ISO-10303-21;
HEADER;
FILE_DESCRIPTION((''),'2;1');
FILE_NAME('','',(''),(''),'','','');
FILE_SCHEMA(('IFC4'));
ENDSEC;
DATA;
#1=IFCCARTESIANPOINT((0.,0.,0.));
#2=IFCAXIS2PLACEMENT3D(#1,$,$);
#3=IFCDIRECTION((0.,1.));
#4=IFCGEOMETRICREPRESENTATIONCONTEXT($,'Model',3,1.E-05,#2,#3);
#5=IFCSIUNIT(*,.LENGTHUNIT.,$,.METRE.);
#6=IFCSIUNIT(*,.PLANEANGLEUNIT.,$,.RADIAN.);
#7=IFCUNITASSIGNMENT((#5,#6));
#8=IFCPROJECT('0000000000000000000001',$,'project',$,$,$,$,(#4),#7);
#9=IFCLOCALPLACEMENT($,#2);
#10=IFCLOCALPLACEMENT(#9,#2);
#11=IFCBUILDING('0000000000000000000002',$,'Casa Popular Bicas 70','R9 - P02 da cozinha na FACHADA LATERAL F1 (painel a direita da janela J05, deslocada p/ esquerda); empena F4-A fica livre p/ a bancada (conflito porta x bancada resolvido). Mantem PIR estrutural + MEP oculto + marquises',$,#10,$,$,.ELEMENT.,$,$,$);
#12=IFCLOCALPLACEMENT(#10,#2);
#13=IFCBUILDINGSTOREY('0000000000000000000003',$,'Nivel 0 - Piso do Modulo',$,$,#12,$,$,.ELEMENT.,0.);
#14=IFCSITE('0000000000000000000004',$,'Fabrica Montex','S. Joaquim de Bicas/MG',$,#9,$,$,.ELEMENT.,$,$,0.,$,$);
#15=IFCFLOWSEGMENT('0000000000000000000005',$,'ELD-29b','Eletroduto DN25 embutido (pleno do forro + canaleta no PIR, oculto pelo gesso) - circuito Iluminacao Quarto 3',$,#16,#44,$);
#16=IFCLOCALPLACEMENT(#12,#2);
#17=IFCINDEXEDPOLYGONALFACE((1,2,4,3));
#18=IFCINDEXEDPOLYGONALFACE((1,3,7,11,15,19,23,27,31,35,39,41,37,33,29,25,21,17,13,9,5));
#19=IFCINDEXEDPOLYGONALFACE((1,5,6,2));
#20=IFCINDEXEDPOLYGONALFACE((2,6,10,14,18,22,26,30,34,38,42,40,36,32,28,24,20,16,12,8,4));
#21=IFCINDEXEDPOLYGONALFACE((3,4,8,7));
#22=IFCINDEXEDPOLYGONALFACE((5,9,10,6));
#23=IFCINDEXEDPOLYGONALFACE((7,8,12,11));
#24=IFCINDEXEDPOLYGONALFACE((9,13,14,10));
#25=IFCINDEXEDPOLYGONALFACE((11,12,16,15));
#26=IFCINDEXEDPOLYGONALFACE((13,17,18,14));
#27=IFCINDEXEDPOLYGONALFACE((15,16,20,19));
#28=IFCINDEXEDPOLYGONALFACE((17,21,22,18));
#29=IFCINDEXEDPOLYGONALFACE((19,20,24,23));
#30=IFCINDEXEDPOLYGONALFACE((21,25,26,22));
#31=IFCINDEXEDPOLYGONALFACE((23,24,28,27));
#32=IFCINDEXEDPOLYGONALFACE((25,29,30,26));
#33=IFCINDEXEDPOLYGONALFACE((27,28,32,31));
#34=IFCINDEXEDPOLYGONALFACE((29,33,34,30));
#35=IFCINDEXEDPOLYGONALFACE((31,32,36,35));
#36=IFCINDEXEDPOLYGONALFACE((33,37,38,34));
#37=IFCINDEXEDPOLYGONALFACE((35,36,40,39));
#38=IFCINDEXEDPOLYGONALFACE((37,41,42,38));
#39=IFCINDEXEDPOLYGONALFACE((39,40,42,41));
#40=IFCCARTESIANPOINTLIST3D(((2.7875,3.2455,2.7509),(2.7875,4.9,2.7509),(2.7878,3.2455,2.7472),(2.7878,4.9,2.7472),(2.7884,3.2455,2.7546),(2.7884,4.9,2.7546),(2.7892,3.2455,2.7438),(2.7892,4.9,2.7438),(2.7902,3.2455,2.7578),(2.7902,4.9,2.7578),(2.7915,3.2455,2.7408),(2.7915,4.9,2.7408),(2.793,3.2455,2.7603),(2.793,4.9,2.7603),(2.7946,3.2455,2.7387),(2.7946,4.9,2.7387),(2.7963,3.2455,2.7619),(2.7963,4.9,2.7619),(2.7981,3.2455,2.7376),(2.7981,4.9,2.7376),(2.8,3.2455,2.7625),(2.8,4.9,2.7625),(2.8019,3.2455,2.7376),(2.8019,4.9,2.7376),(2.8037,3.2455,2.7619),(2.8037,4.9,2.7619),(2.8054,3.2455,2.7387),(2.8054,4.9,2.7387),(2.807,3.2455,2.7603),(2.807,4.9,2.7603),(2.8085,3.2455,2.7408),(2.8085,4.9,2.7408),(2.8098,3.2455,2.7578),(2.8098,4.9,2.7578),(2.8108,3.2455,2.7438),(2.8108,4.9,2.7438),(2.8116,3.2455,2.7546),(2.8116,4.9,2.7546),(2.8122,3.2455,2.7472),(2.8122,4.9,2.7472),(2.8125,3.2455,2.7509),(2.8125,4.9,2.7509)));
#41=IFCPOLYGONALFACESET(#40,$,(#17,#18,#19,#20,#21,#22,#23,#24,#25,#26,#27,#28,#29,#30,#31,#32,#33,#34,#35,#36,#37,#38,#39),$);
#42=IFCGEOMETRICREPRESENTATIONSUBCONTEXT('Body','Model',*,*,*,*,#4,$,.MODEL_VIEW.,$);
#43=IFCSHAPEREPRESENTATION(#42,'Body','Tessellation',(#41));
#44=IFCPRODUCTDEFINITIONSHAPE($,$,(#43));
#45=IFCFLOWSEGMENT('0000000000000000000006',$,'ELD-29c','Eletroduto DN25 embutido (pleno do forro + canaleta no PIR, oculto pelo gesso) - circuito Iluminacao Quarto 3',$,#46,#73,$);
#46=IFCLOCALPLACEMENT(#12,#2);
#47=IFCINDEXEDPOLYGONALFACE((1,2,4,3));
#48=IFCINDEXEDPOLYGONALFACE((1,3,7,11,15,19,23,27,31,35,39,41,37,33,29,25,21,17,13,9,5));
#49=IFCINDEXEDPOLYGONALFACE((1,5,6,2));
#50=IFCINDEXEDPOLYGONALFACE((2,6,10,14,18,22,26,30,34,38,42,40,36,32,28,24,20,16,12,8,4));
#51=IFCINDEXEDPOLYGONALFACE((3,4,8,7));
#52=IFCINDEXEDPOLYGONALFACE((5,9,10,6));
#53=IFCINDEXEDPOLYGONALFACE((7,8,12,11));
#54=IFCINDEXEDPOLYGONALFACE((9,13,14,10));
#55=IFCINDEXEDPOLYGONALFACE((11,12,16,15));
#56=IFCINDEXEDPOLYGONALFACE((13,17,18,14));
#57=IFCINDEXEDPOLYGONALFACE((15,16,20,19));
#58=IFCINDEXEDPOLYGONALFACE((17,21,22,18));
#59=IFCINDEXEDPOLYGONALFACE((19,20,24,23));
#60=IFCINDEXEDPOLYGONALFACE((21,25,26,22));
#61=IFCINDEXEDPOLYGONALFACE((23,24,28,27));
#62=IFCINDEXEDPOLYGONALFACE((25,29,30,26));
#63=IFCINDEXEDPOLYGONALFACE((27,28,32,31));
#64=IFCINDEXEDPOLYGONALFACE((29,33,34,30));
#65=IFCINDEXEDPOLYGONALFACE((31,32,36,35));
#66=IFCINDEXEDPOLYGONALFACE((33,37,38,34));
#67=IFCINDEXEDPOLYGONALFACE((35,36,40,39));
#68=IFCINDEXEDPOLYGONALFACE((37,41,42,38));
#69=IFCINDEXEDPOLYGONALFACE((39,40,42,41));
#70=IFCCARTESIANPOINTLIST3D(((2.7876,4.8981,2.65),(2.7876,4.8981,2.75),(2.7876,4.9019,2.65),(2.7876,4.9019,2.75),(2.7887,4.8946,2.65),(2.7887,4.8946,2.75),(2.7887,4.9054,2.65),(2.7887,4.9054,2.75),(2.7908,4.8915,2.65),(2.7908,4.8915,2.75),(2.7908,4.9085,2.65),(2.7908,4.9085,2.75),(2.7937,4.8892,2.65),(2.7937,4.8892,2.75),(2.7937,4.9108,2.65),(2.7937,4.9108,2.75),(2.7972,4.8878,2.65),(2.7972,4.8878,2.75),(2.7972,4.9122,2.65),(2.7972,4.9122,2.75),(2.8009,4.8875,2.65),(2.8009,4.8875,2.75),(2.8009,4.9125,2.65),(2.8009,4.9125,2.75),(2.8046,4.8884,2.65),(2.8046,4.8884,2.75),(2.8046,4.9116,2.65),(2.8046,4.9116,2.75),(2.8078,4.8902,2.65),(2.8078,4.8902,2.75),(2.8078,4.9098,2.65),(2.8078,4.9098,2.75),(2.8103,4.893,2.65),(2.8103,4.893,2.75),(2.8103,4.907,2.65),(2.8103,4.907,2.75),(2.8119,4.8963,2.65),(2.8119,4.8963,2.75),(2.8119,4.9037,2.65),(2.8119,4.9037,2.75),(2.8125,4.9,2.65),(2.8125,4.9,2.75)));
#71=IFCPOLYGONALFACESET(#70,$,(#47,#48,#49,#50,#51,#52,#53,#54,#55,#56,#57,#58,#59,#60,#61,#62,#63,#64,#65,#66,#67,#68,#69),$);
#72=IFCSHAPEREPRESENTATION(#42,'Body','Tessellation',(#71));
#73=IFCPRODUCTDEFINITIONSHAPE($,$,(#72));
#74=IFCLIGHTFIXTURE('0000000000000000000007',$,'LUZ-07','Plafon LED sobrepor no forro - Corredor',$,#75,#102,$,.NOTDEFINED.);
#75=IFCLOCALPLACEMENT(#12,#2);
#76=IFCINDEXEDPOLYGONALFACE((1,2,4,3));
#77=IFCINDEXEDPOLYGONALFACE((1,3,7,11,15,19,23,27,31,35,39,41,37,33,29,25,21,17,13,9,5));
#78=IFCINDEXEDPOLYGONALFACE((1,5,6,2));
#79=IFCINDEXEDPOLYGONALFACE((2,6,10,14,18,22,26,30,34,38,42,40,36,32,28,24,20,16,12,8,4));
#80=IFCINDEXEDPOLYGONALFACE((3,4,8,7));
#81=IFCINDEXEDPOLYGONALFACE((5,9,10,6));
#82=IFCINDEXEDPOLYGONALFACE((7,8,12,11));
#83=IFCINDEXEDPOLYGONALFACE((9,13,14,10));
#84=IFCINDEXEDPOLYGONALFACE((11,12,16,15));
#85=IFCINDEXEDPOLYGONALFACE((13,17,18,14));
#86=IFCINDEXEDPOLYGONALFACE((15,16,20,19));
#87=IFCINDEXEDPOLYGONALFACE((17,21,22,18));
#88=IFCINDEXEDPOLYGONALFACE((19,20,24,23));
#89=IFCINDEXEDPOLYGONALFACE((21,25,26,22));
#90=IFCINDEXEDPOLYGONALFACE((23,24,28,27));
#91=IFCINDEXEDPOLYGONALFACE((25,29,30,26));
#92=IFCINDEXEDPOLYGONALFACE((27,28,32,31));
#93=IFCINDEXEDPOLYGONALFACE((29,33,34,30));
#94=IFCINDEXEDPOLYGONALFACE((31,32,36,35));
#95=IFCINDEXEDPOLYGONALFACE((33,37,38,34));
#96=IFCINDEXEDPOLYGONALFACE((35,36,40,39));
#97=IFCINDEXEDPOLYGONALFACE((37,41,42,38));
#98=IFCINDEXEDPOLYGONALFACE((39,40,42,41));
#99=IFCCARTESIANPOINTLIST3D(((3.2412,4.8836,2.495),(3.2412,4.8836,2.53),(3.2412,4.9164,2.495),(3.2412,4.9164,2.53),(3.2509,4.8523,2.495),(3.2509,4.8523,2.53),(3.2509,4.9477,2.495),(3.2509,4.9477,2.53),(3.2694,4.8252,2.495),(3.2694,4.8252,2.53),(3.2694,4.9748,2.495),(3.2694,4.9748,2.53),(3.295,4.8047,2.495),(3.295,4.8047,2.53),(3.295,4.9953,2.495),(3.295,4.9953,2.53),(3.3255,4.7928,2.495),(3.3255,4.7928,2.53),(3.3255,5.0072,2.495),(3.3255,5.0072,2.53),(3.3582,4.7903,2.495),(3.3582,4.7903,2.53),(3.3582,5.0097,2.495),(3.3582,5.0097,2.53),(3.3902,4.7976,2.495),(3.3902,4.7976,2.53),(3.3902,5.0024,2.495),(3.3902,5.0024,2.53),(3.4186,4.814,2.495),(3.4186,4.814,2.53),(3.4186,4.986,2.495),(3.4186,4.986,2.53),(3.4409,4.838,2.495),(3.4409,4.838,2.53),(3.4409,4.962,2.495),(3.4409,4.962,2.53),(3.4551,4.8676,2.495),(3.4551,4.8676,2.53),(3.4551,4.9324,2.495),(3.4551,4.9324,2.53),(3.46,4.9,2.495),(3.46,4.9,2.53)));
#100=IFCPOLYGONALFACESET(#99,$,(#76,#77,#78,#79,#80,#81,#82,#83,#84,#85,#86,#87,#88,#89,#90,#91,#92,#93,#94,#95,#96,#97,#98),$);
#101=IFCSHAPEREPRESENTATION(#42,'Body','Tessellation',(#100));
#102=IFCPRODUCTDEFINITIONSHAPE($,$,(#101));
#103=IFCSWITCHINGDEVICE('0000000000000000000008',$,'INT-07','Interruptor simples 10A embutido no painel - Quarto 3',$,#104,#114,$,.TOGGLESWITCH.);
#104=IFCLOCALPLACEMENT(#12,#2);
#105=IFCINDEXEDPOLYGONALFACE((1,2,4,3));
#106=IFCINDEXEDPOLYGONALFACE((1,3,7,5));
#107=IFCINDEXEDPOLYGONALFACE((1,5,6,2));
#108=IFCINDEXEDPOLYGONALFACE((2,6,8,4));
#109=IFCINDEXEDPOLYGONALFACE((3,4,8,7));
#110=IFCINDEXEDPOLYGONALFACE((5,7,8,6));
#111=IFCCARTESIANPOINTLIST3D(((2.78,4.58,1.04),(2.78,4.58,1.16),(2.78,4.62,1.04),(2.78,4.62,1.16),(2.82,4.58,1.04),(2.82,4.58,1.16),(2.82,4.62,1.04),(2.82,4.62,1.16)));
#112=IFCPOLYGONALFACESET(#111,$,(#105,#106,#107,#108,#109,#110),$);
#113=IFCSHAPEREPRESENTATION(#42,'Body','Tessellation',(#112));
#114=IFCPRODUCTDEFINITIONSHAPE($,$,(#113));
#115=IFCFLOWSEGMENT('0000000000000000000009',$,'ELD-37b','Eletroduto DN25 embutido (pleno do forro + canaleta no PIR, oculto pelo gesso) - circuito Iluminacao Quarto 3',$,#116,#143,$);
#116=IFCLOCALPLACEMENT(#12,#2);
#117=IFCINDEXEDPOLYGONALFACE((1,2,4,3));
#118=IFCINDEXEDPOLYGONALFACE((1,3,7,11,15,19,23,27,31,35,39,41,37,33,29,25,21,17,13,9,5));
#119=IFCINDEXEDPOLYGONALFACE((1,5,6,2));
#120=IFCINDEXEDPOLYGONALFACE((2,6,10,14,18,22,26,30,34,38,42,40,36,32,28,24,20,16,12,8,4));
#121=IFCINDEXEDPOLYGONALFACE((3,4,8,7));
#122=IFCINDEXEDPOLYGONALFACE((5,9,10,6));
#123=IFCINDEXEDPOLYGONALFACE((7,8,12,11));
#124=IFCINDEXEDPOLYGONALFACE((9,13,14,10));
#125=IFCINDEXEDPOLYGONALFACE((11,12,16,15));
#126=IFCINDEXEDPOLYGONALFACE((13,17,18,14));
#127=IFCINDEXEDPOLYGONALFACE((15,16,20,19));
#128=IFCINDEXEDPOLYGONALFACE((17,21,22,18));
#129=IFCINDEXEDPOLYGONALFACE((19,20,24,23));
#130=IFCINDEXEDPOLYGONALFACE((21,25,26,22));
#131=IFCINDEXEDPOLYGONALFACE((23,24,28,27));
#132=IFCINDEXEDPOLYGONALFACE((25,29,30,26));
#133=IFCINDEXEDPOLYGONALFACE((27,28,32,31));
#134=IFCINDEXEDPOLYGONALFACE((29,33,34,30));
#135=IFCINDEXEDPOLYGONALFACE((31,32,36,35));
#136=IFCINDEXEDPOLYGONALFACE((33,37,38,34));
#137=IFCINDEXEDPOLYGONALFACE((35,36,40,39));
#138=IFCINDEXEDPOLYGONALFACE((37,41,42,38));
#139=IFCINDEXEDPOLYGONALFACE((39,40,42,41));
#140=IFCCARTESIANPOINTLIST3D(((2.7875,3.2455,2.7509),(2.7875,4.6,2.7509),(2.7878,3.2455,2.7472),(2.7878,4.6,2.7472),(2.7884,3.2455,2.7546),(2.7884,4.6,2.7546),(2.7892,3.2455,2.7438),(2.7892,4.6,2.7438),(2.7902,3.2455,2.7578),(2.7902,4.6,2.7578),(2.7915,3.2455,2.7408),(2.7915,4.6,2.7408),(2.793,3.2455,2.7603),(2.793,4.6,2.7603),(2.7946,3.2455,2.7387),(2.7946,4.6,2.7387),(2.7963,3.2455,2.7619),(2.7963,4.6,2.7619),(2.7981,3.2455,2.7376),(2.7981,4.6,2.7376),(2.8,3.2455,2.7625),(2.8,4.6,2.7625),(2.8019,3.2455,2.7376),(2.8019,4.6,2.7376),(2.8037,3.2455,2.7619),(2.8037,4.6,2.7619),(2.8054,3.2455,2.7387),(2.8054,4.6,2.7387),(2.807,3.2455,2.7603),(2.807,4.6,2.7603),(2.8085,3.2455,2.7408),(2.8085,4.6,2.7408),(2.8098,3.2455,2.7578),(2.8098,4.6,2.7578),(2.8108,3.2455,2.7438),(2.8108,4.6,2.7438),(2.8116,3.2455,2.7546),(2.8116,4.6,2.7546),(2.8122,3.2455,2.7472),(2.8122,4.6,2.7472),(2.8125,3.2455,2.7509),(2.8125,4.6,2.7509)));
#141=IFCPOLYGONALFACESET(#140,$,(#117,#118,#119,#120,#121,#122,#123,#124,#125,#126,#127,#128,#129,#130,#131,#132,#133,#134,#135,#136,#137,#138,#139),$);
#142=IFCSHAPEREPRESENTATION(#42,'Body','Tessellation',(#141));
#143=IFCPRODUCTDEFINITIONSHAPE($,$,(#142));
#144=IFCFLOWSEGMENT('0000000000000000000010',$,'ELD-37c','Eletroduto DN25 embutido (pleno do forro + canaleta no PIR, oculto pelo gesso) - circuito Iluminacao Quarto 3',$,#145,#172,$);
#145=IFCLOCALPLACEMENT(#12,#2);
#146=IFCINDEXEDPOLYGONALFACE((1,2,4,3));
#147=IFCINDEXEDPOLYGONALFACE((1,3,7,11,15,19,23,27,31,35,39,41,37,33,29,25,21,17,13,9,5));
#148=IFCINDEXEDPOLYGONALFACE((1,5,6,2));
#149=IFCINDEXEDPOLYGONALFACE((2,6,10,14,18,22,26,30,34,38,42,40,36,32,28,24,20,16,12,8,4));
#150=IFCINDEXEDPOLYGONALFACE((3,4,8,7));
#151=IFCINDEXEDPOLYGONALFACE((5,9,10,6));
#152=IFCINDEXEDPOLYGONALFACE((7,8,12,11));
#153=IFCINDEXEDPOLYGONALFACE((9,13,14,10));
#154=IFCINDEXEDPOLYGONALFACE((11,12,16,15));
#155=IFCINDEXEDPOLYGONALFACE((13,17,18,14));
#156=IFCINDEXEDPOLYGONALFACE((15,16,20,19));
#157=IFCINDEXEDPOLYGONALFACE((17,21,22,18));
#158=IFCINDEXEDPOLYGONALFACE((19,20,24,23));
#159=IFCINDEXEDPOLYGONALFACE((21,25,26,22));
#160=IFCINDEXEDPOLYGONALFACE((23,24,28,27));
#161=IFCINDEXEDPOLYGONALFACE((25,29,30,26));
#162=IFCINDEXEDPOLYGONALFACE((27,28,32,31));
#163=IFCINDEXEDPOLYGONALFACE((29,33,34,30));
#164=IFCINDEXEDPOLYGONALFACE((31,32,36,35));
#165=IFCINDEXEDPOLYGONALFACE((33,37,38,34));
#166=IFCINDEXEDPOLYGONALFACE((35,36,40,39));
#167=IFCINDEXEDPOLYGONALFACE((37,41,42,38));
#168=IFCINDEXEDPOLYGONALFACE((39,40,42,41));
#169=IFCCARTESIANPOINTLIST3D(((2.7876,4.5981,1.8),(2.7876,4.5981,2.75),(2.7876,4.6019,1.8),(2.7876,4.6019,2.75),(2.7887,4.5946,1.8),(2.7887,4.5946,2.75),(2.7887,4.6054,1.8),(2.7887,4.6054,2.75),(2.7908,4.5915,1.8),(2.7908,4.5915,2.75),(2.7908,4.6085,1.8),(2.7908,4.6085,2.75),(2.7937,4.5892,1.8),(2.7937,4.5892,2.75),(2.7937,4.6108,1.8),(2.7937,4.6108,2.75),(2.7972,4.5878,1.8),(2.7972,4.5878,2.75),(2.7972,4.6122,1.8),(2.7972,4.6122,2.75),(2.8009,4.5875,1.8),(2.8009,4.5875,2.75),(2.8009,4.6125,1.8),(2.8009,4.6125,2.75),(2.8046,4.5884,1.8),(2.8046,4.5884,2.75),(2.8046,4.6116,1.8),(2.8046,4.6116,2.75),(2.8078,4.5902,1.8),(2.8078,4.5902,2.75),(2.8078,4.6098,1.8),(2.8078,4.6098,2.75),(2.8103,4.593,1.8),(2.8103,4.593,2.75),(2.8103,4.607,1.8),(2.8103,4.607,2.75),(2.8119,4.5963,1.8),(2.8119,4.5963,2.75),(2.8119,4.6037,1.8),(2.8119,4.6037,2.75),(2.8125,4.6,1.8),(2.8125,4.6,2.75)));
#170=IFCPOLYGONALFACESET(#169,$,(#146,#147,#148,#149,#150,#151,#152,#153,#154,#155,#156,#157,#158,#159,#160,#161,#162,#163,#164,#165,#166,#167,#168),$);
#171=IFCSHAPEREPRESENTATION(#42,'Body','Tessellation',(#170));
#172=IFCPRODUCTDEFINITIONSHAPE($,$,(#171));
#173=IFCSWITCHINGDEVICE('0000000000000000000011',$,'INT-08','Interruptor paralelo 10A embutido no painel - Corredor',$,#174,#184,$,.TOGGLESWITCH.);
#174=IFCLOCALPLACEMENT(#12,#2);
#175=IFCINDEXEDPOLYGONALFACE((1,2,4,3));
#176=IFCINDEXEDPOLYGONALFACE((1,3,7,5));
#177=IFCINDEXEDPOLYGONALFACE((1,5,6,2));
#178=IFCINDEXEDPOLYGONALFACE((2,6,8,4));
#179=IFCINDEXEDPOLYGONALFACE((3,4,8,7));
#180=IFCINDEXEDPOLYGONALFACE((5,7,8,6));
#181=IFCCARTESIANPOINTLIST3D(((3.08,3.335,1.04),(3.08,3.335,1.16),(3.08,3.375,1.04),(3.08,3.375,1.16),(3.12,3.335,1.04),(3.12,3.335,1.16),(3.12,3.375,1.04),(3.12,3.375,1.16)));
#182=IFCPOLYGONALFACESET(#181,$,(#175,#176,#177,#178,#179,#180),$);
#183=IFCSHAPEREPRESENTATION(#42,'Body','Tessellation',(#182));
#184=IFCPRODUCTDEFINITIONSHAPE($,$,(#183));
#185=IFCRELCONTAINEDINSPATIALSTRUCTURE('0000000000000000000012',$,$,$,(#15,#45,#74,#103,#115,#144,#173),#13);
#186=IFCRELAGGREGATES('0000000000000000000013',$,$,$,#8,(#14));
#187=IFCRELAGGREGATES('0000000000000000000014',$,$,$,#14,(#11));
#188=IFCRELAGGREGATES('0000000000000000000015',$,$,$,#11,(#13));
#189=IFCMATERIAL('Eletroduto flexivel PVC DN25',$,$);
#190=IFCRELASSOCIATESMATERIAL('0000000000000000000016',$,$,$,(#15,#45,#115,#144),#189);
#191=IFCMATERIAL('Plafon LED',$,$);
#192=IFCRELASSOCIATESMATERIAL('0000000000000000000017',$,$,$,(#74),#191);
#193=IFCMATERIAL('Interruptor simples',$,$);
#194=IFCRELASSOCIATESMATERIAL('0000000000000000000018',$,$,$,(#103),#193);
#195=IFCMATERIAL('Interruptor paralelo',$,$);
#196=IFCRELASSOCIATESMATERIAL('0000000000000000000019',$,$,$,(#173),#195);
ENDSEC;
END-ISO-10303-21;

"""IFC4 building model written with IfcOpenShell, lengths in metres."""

from ifc_helpers import new_model, si_unit, direction, frame, frame_2d, origin, origin_2d, place, context, subcontext, project, spatial, rectangle, circle, extrude, material, element, save


model = new_model("IFC4")

# Units and contexts
model_context = context("Model", 3, precision=1e-05, world=origin(), true_north=direction((0.0, 1.0)))
body_context = subcontext(model_context, "Body", "Model", "MODEL_VIEW")
ifc_project = project(units=[si_unit("LENGTHUNIT", "METRE"), si_unit("PLANEANGLEUNIT", "RADIAN")], contexts=[model_context])

# Site, building, storey
site_placement = place(None, origin())
site = spatial("IfcSite", under=ifc_project, at=site_placement, Name="Fabrica Montex", Description="S. Joaquim de Bicas/MG", CompositionType="ELEMENT", RefElevation=0.0)
building_placement = place(site_placement, origin())
building = spatial("IfcBuilding", under=site, at=building_placement, Name="Casa Popular Bicas 70", Description="R9 - P02 da cozinha na FACHADA LATERAL F1 (painel a direita da janela J05, deslocada p/ esquerda); empena F4-A fica livre p/ a bancada (conflito porta x bancada resolvido). Mantem PIR estrutural + MEP oculto + marquises", CompositionType="ELEMENT")
storey_placement = place(building_placement, origin())
storey = spatial("IfcBuildingStorey", under=building, at=storey_placement, Name="Nivel 0 - Piso do Modulo", CompositionType="ELEMENT", Elevation=0.0)

# Shared definitions
ifc_material_1 = material(Name="Eletroduto flexivel PVC DN25")

# Flow segments
flow_segment_1_placement = place(storey_placement, frame((2.8, 3.2455, 2.75), z_axis=(0.0, 1.0, 0.0), x_axis=(0.0, 0.0, 1.0)))
element("IfcFlowSegment", 1, at=flow_segment_1_placement, inside=storey, material=ifc_material_1, Name="ELD-29b", Description="Eletroduto DN25 embutido (pleno do forro + canaleta no PIR, oculto pelo gesso) - circuito Iluminacao Quarto 3", context=body_context, shape_type="SweptSolid", body=[
    extrude(circle(Radius=0.0125, at=origin_2d()), origin(), (0.0, 0.0, 1.0), 1.6545),
])
flow_segment_2_placement = place(storey_placement, frame((2.8, 4.9, 2.75), z_axis=(0.0, 0.0, -1.0), x_axis=(1.0, 0.0, 0.0)))
element("IfcFlowSegment", 2, at=flow_segment_2_placement, inside=storey, material=ifc_material_1, Name="ELD-29c", Description="Eletroduto DN25 embutido (pleno do forro + canaleta no PIR, oculto pelo gesso) - circuito Iluminacao Quarto 3", context=body_context, shape_type="SweptSolid", body=[
    extrude(circle(Radius=0.0125, at=origin_2d()), origin(), (0.0, 0.0, 1.0), 0.1),
])

# Light fixture
ifc_material_2 = material(Name="Plafon LED")
light_fixture_placement = place(storey_placement, frame((3.35, 4.9, 2.495)))
element("IfcLightFixture", 3, at=light_fixture_placement, inside=storey, material=ifc_material_2, Name="LUZ-07", Description="Plafon LED sobrepor no forro - Corredor", PredefinedType="NOTDEFINED", context=body_context, shape_type="SweptSolid", body=[
    extrude(circle(Radius=0.11, at=origin_2d()), origin(), (0.0, 0.0, 1.0), 0.035),
])

# Switching device
ifc_material_3 = material(Name="Interruptor simples")
switching_device_1_placement = place(storey_placement, frame((2.78, 4.58, 1.04)))
element("IfcSwitchingDevice", 4, at=switching_device_1_placement, inside=storey, material=ifc_material_3, Name="INT-07", Description="Interruptor simples 10A embutido no painel - Quarto 3", PredefinedType="TOGGLESWITCH", context=body_context, shape_type="SweptSolid", body=[
    extrude(rectangle(XDim=0.04, YDim=0.04, at=frame_2d((0.02, 0.02))), origin(), (0.0, 0.0, 1.0), 0.12),
])

# Flow segments
flow_segment_3_placement = place(storey_placement, frame((2.8, 3.2455, 2.75), z_axis=(0.0, 1.0, 0.0), x_axis=(0.0, 0.0, 1.0)))
element("IfcFlowSegment", 5, at=flow_segment_3_placement, inside=storey, material=ifc_material_1, Name="ELD-37b", Description="Eletroduto DN25 embutido (pleno do forro + canaleta no PIR, oculto pelo gesso) - circuito Iluminacao Quarto 3", context=body_context, shape_type="SweptSolid", body=[
    extrude(circle(Radius=0.0125, at=origin_2d()), origin(), (0.0, 0.0, 1.0), 1.3545),
])
flow_segment_4_placement = place(storey_placement, frame((2.8, 4.6, 2.75), z_axis=(0.0, 0.0, -1.0), x_axis=(1.0, 0.0, 0.0)))
element("IfcFlowSegment", 6, at=flow_segment_4_placement, inside=storey, material=ifc_material_1, Name="ELD-37c", Description="Eletroduto DN25 embutido (pleno do forro + canaleta no PIR, oculto pelo gesso) - circuito Iluminacao Quarto 3", context=body_context, shape_type="SweptSolid", body=[
    extrude(circle(Radius=0.0125, at=origin_2d()), origin(), (0.0, 0.0, 1.0), 0.95),
])

# Switching device
ifc_material_4 = material(Name="Interruptor paralelo")
switching_device_2_placement = place(storey_placement, frame((3.08, 3.335, 1.04)))
element("IfcSwitchingDevice", 7, at=switching_device_2_placement, inside=storey, material=ifc_material_4, Name="INT-08", Description="Interruptor paralelo 10A embutido no painel - Corredor", PredefinedType="TOGGLESWITCH", context=body_context, shape_type="SweptSolid", body=[
    extrude(rectangle(XDim=0.04, YDim=0.04, at=frame_2d((0.02, 0.02))), origin(), (0.0, 0.0, 1.0), 0.12),
])

save(model, "model.ifc")
